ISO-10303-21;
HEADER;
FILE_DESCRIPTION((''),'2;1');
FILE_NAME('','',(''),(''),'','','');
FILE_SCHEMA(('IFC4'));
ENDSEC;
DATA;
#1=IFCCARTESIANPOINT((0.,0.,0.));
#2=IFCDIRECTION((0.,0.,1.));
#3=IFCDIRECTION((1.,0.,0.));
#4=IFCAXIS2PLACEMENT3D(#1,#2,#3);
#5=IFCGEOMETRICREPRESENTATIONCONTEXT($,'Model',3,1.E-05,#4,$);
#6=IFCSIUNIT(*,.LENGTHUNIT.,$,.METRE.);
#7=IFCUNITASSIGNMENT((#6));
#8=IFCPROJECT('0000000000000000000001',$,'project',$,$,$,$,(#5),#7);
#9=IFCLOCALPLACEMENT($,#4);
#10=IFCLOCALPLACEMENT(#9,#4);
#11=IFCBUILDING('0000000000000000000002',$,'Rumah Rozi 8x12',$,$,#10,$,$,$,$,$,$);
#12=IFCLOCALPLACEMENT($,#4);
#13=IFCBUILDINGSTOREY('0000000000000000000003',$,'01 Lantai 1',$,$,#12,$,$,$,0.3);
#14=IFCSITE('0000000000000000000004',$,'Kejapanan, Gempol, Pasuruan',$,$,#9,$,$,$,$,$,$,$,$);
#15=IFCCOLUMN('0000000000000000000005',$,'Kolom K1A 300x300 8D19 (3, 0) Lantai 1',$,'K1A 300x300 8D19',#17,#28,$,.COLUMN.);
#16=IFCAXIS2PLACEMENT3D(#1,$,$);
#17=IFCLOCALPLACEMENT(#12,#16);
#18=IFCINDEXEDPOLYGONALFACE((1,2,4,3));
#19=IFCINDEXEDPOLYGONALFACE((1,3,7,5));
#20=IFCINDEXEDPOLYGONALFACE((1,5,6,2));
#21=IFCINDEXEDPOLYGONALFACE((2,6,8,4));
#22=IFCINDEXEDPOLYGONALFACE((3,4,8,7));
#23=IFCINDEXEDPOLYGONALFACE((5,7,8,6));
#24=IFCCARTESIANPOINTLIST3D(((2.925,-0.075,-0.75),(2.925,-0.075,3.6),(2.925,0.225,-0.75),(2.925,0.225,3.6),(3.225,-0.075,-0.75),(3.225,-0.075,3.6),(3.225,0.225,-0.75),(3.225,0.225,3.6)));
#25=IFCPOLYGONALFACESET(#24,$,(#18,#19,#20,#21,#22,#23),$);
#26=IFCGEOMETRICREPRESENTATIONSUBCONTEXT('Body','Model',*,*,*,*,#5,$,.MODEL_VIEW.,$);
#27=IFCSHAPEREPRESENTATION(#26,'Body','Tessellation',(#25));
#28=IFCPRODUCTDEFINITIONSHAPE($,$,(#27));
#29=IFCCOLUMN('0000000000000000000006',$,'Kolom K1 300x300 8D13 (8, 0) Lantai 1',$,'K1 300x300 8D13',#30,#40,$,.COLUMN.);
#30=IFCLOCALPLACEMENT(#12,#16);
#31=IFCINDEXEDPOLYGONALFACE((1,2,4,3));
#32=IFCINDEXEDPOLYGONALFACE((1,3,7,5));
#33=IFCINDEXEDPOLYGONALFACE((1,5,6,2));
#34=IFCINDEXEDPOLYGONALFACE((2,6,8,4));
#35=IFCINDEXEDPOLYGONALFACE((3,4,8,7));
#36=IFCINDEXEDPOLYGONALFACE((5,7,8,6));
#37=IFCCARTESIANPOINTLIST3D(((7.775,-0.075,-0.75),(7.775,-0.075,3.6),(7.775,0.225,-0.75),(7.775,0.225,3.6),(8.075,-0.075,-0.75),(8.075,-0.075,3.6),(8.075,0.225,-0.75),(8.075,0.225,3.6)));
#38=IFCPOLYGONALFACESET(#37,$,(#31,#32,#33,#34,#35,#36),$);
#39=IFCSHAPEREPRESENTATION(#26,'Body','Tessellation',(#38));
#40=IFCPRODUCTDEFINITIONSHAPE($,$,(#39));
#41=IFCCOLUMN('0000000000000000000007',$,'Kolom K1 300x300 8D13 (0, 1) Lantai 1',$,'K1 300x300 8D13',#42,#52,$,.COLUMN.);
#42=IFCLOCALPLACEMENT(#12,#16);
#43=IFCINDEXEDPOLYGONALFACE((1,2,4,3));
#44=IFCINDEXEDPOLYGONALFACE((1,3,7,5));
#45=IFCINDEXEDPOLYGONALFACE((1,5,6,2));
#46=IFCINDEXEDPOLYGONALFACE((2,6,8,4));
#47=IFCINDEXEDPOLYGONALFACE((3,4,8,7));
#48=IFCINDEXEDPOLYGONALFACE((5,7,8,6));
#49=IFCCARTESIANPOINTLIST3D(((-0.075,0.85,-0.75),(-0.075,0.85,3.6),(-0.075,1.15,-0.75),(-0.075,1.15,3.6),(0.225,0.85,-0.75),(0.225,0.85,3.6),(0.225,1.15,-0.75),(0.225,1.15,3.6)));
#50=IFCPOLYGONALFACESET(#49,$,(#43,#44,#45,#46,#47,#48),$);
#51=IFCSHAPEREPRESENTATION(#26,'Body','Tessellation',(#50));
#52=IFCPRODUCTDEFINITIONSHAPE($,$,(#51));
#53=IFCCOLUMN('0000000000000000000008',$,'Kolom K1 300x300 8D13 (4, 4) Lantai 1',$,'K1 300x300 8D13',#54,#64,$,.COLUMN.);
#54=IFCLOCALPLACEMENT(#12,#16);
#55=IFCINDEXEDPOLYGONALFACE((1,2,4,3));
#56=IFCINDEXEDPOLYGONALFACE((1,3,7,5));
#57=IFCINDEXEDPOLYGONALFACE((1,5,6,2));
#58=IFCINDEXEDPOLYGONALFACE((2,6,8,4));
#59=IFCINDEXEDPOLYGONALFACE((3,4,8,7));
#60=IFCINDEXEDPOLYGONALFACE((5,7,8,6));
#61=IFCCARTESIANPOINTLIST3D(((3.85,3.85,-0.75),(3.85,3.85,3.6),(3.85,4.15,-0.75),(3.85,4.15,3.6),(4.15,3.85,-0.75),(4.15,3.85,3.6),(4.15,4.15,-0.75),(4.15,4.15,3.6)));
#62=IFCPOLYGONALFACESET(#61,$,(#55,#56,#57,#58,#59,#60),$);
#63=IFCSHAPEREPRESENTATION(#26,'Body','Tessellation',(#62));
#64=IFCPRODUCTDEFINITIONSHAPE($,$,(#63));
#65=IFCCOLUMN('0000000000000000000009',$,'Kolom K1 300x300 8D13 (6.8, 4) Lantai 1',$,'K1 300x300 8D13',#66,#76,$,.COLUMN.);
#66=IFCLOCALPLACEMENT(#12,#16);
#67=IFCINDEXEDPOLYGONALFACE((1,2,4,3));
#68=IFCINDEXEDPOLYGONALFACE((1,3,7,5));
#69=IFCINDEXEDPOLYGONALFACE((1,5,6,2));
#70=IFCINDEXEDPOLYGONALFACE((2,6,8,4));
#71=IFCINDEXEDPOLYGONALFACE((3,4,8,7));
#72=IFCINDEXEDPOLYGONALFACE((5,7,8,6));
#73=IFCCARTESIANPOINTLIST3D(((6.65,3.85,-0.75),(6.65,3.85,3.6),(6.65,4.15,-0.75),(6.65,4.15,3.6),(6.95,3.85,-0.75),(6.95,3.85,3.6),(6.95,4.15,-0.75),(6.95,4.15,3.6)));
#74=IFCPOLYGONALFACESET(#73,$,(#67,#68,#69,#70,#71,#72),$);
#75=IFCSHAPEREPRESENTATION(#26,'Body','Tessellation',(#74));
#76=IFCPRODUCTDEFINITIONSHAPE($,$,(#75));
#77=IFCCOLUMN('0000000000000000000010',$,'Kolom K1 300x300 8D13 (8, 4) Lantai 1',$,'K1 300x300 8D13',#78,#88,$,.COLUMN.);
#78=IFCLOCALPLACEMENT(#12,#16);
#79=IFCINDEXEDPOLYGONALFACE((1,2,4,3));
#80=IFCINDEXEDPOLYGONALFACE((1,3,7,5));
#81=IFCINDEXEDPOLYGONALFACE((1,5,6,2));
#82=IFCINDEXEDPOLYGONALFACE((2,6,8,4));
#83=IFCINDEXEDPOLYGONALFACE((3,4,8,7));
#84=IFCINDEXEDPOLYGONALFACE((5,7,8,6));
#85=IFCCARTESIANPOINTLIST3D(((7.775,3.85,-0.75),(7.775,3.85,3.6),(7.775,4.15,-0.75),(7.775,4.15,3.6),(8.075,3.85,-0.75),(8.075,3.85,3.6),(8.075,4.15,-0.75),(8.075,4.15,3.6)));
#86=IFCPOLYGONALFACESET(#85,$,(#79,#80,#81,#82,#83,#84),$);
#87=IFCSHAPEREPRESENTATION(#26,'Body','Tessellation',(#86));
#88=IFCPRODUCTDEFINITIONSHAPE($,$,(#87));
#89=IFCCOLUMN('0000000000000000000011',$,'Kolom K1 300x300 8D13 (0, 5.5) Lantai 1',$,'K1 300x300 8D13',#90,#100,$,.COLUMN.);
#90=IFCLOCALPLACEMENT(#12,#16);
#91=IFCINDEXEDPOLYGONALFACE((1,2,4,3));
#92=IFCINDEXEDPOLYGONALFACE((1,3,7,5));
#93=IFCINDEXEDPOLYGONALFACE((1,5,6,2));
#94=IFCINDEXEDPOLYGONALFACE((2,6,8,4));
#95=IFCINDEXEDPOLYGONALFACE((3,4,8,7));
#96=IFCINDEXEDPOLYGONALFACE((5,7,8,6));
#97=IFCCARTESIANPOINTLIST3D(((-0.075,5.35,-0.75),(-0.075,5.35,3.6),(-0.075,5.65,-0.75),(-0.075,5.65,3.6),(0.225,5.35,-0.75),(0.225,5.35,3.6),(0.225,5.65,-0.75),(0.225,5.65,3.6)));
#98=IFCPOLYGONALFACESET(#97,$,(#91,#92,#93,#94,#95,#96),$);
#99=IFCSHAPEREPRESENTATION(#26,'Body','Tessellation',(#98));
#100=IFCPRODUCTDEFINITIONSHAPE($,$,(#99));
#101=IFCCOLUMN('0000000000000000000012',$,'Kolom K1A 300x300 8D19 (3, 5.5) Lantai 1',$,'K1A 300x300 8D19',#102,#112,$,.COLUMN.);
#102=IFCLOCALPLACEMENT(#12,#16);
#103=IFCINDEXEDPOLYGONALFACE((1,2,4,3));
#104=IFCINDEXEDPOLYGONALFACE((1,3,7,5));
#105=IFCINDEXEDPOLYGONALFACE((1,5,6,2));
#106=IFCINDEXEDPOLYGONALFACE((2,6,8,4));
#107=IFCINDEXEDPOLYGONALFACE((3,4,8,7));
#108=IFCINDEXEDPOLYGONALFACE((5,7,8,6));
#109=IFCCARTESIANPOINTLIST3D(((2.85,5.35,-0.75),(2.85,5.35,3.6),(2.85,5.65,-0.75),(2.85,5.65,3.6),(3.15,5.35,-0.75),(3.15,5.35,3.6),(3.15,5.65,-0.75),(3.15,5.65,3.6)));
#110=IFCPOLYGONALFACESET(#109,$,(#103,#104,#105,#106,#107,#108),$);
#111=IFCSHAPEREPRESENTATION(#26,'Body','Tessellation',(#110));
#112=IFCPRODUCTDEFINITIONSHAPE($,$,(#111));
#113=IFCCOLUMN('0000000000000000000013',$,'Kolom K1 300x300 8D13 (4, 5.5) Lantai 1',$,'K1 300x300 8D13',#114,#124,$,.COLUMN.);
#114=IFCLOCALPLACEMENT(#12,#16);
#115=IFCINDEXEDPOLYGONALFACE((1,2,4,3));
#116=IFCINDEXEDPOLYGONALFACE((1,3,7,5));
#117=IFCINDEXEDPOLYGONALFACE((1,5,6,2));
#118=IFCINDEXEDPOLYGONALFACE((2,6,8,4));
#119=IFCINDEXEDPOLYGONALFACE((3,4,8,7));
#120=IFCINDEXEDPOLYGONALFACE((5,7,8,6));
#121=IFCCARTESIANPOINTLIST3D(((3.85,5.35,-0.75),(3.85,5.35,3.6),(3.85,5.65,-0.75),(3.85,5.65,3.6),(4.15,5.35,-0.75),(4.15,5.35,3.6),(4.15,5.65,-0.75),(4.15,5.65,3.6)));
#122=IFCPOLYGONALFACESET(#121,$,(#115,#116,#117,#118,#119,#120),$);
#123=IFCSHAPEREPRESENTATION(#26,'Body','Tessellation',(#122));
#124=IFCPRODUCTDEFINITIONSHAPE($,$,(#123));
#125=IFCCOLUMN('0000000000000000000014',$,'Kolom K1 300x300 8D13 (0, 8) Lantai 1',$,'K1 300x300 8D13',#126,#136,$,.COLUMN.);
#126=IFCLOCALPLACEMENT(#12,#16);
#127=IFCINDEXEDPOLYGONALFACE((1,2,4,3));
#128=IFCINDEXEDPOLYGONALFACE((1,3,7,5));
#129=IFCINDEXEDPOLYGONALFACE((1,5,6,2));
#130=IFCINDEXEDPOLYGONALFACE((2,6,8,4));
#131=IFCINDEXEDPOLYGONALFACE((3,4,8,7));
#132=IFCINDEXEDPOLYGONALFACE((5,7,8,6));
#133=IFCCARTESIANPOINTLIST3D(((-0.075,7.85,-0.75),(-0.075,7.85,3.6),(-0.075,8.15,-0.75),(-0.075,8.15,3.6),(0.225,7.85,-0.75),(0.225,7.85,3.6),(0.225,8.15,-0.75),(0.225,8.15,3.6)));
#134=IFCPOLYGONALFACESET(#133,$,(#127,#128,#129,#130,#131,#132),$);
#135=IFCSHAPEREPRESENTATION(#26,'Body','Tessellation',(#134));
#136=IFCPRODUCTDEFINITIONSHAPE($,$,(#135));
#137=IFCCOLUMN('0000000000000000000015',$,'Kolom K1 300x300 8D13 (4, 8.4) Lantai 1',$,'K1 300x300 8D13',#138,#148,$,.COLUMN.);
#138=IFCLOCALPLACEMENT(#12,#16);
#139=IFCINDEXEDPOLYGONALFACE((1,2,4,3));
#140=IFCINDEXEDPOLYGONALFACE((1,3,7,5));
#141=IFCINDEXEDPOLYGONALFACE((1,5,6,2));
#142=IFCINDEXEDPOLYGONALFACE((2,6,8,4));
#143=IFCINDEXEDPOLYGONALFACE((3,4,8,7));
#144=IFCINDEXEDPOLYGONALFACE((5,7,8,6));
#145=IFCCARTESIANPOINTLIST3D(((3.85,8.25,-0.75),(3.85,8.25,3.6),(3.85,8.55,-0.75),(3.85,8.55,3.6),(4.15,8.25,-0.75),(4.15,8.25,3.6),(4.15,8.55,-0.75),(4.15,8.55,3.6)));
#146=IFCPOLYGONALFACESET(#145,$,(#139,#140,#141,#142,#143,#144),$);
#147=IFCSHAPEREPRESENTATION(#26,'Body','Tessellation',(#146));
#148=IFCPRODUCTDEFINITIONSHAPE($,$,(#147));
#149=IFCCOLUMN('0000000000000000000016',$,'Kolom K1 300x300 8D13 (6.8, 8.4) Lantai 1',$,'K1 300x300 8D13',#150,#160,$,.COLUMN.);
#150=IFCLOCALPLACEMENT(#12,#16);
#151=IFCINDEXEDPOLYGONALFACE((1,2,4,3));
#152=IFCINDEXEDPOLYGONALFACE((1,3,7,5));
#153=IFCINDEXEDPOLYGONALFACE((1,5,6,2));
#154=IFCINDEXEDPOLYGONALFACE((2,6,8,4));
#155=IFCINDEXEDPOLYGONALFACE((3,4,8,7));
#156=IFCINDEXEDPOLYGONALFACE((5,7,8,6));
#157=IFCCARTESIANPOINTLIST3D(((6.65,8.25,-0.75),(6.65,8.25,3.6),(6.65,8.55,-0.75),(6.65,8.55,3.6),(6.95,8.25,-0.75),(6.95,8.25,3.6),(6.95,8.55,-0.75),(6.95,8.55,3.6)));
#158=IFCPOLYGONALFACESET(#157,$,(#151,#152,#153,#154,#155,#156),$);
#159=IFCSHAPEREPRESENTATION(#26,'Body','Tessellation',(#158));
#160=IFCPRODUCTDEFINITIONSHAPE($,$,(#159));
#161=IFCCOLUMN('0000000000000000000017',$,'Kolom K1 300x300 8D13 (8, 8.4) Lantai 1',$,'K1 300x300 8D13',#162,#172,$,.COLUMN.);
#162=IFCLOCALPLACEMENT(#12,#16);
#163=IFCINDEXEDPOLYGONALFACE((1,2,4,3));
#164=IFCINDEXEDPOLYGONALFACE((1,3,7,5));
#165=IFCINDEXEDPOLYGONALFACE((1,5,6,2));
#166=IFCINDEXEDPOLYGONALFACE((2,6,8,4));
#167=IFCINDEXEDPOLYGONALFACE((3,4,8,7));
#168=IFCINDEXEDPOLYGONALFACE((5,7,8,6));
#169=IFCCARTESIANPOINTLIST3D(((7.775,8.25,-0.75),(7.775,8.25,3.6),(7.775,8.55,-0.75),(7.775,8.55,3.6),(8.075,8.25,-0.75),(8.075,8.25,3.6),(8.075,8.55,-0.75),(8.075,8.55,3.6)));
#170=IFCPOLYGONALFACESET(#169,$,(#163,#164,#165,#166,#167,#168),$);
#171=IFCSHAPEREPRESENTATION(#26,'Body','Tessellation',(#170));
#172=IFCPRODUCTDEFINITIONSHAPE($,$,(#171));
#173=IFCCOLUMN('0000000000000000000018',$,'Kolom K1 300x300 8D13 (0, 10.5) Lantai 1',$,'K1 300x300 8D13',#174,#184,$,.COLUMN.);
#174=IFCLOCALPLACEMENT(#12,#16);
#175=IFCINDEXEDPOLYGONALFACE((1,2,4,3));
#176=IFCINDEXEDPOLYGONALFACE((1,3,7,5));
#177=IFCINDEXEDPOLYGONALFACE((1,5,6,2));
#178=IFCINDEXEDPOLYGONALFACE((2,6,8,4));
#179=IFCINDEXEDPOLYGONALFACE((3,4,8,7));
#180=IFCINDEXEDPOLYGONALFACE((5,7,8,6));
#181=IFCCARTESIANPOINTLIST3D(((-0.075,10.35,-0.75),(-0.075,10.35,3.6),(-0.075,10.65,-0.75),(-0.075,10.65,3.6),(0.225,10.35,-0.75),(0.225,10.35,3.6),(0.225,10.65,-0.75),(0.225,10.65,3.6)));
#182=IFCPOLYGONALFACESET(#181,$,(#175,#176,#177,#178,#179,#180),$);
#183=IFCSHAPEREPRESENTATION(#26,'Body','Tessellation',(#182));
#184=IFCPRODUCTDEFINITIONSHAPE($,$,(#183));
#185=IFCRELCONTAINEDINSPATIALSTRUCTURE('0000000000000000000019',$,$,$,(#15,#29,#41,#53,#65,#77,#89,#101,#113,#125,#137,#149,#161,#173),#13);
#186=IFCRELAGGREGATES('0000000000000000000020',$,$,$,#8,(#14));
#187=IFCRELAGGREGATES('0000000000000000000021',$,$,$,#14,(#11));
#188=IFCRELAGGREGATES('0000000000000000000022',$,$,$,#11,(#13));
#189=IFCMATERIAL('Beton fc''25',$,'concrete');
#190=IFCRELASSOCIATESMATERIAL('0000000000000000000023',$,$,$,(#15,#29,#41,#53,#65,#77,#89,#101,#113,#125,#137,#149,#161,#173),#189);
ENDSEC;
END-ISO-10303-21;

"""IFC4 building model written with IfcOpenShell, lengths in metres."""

from ifc_helpers import new_model, si_unit, frame, origin_with_axes, place, context, subcontext, project, spatial, line, indexed_curve, outline, extrude, material, element, save


model = new_model("IFC4")

# Units and contexts
model_context = context("Model", 3, precision=1e-05, world=origin_with_axes())
body_context = subcontext(model_context, "Body", "Model", "MODEL_VIEW")
ifc_project = project(units=[si_unit("LENGTHUNIT", "METRE")], contexts=[model_context])

# Site, building, storey
site_placement = place(None, origin_with_axes())
site = spatial("IfcSite", under=ifc_project, at=site_placement, Name="Kejapanan, Gempol, Pasuruan")
building_placement = place(site_placement, origin_with_axes())
building = spatial("IfcBuilding", under=site, at=building_placement, Name="Rumah Rozi 8x12")
storey_placement = place(None, origin_with_axes())
storey = spatial("IfcBuildingStorey", under=building, at=storey_placement, Name="01 Lantai 1", Elevation=0.3)

# Columns
ifc_material = material(Name="Beton fc'25", Category="concrete")
column_1_placement = place(storey_placement, origin_with_axes())
element("IfcColumn", 1, at=column_1_placement, inside=storey, material=ifc_material, Name="Kolom K1A 300x300 8D19 (3, 0) Lantai 1", ObjectType="K1A 300x300 8D19", PredefinedType="COLUMN", context=body_context, shape_type="SweptSolid", body=[
    extrude(outline(indexed_curve([(2.925, -0.075), (3.225, -0.075), (3.225, 0.225), (2.925, 0.225)], segments=[line(1, 2, 3, 4, 1)])), frame((0.0, 0.0, -0.75), z_axis=(0.0, 0.0, 1.0), x_axis=(1.0, 0.0, 0.0)), (0.0, 0.0, 1.0), 4.35),
])
column_2_placement = place(storey_placement, origin_with_axes())
element("IfcColumn", 2, at=column_2_placement, inside=storey, material=ifc_material, Name="Kolom K1 300x300 8D13 (8, 0) Lantai 1", ObjectType="K1 300x300 8D13", PredefinedType="COLUMN", context=body_context, shape_type="SweptSolid", body=[
    extrude(outline(indexed_curve([(7.775, -0.075), (8.075, -0.075), (8.075, 0.225), (7.775, 0.225)], segments=[line(1, 2, 3, 4, 1)])), frame((0.0, 0.0, -0.75), z_axis=(0.0, 0.0, 1.0), x_axis=(1.0, 0.0, 0.0)), (0.0, 0.0, 1.0), 4.35),
])
column_3_placement = place(storey_placement, origin_with_axes())
element("IfcColumn", 3, at=column_3_placement, inside=storey, material=ifc_material, Name="Kolom K1 300x300 8D13 (0, 1) Lantai 1", ObjectType="K1 300x300 8D13", PredefinedType="COLUMN", context=body_context, shape_type="SweptSolid", body=[
    extrude(outline(indexed_curve([(-0.075, 0.85), (0.225, 0.85), (0.225, 1.15), (-0.075, 1.15)], segments=[line(1, 2, 3, 4, 1)])), frame((0.0, 0.0, -0.75), z_axis=(0.0, 0.0, 1.0), x_axis=(1.0, 0.0, 0.0)), (0.0, 0.0, 1.0), 4.35),
])
column_4_placement = place(storey_placement, origin_with_axes())
element("IfcColumn", 4, at=column_4_placement, inside=storey, material=ifc_material, Name="Kolom K1 300x300 8D13 (4, 4) Lantai 1", ObjectType="K1 300x300 8D13", PredefinedType="COLUMN", context=body_context, shape_type="SweptSolid", body=[
    extrude(outline(indexed_curve([(3.85, 3.85), (4.15, 3.85), (4.15, 4.15), (3.85, 4.15)], segments=[line(1, 2, 3, 4, 1)])), frame((0.0, 0.0, -0.75), z_axis=(0.0, 0.0, 1.0), x_axis=(1.0, 0.0, 0.0)), (0.0, 0.0, 1.0), 4.35),
])
column_5_placement = place(storey_placement, origin_with_axes())
element("IfcColumn", 5, at=column_5_placement, inside=storey, material=ifc_material, Name="Kolom K1 300x300 8D13 (6.8, 4) Lantai 1", ObjectType="K1 300x300 8D13", PredefinedType="COLUMN", context=body_context, shape_type="SweptSolid", body=[
    extrude(outline(indexed_curve([(6.65, 3.85), (6.95, 3.85), (6.95, 4.15), (6.65, 4.15)], segments=[line(1, 2, 3, 4, 1)])), frame((0.0, 0.0, -0.75), z_axis=(0.0, 0.0, 1.0), x_axis=(1.0, 0.0, 0.0)), (0.0, 0.0, 1.0), 4.35),
])
column_6_placement = place(storey_placement, origin_with_axes())
element("IfcColumn", 6, at=column_6_placement, inside=storey, material=ifc_material, Name="Kolom K1 300x300 8D13 (8, 4) Lantai 1", ObjectType="K1 300x300 8D13", PredefinedType="COLUMN", context=body_context, shape_type="SweptSolid", body=[
    extrude(outline(indexed_curve([(7.775, 3.85), (8.075, 3.85), (8.075, 4.15), (7.775, 4.15)], segments=[line(1, 2, 3, 4, 1)])), frame((0.0, 0.0, -0.75), z_axis=(0.0, 0.0, 1.0), x_axis=(1.0, 0.0, 0.0)), (0.0, 0.0, 1.0), 4.35),
])
column_7_placement = place(storey_placement, origin_with_axes())
element("IfcColumn", 7, at=column_7_placement, inside=storey, material=ifc_material, Name="Kolom K1 300x300 8D13 (0, 5.5) Lantai 1", ObjectType="K1 300x300 8D13", PredefinedType="COLUMN", context=body_context, shape_type="SweptSolid", body=[
    extrude(outline(indexed_curve([(-0.075, 5.35), (0.225, 5.35), (0.225, 5.65), (-0.075, 5.65)], segments=[line(1, 2, 3, 4, 1)])), frame((0.0, 0.0, -0.75), z_axis=(0.0, 0.0, 1.0), x_axis=(1.0, 0.0, 0.0)), (0.0, 0.0, 1.0), 4.35),
])
column_8_placement = place(storey_placement, origin_with_axes())
element("IfcColumn", 8, at=column_8_placement, inside=storey, material=ifc_material, Name="Kolom K1A 300x300 8D19 (3, 5.5) Lantai 1", ObjectType="K1A 300x300 8D19", PredefinedType="COLUMN", context=body_context, shape_type="SweptSolid", body=[
    extrude(outline(indexed_curve([(2.85, 5.35), (3.15, 5.35), (3.15, 5.65), (2.85, 5.65)], segments=[line(1, 2, 3, 4, 1)])), frame((0.0, 0.0, -0.75), z_axis=(0.0, 0.0, 1.0), x_axis=(1.0, 0.0, 0.0)), (0.0, 0.0, 1.0), 4.35),
])
column_9_placement = place(storey_placement, origin_with_axes())
element("IfcColumn", 9, at=column_9_placement, inside=storey, material=ifc_material, Name="Kolom K1 300x300 8D13 (4, 5.5) Lantai 1", ObjectType="K1 300x300 8D13", PredefinedType="COLUMN", context=body_context, shape_type="SweptSolid", body=[
    extrude(outline(indexed_curve([(3.85, 5.35), (4.15, 5.35), (4.15, 5.65), (3.85, 5.65)], segments=[line(1, 2, 3, 4, 1)])), frame((0.0, 0.0, -0.75), z_axis=(0.0, 0.0, 1.0), x_axis=(1.0, 0.0, 0.0)), (0.0, 0.0, 1.0), 4.35),
])
column_10_placement = place(storey_placement, origin_with_axes())
element("IfcColumn", 10, at=column_10_placement, inside=storey, material=ifc_material, Name="Kolom K1 300x300 8D13 (0, 8) Lantai 1", ObjectType="K1 300x300 8D13", PredefinedType="COLUMN", context=body_context, shape_type="SweptSolid", body=[
    extrude(outline(indexed_curve([(-0.075, 7.85), (0.225, 7.85), (0.225, 8.15), (-0.075, 8.15)], segments=[line(1, 2, 3, 4, 1)])), frame((0.0, 0.0, -0.75), z_axis=(0.0, 0.0, 1.0), x_axis=(1.0, 0.0, 0.0)), (0.0, 0.0, 1.0), 4.35),
])
column_11_placement = place(storey_placement, origin_with_axes())
element("IfcColumn", 11, at=column_11_placement, inside=storey, material=ifc_material, Name="Kolom K1 300x300 8D13 (4, 8.4) Lantai 1", ObjectType="K1 300x300 8D13", PredefinedType="COLUMN", context=body_context, shape_type="SweptSolid", body=[
    extrude(outline(indexed_curve([(3.85, 8.25), (4.15, 8.25), (4.15, 8.55), (3.85, 8.55)], segments=[line(1, 2, 3, 4, 1)])), frame((0.0, 0.0, -0.75), z_axis=(0.0, 0.0, 1.0), x_axis=(1.0, 0.0, 0.0)), (0.0, 0.0, 1.0), 4.35),
])
column_12_placement = place(storey_placement, origin_with_axes())
element("IfcColumn", 12, at=column_12_placement, inside=storey, material=ifc_material, Name="Kolom K1 300x300 8D13 (6.8, 8.4) Lantai 1", ObjectType="K1 300x300 8D13", PredefinedType="COLUMN", context=body_context, shape_type="SweptSolid", body=[
    extrude(outline(indexed_curve([(6.65, 8.25), (6.95, 8.25), (6.95, 8.55), (6.65, 8.55)], segments=[line(1, 2, 3, 4, 1)])), frame((0.0, 0.0, -0.75), z_axis=(0.0, 0.0, 1.0), x_axis=(1.0, 0.0, 0.0)), (0.0, 0.0, 1.0), 4.35),
])
column_13_placement = place(storey_placement, origin_with_axes())
element("IfcColumn", 13, at=column_13_placement, inside=storey, material=ifc_material, Name="Kolom K1 300x300 8D13 (8, 8.4) Lantai 1", ObjectType="K1 300x300 8D13", PredefinedType="COLUMN", context=body_context, shape_type="SweptSolid", body=[
    extrude(outline(indexed_curve([(7.775, 8.25), (8.075, 8.25), (8.075, 8.55), (7.775, 8.55)], segments=[line(1, 2, 3, 4, 1)])), frame((0.0, 0.0, -0.75), z_axis=(0.0, 0.0, 1.0), x_axis=(1.0, 0.0, 0.0)), (0.0, 0.0, 1.0), 4.35),
])
column_14_placement = place(storey_placement, origin_with_axes())
element("IfcColumn", 14, at=column_14_placement, inside=storey, material=ifc_material, Name="Kolom K1 300x300 8D13 (0, 10.5) Lantai 1", ObjectType="K1 300x300 8D13", PredefinedType="COLUMN", context=body_context, shape_type="SweptSolid", body=[
    extrude(outline(indexed_curve([(-0.075, 10.35), (0.225, 10.35), (0.225, 10.65), (-0.075, 10.65)], segments=[line(1, 2, 3, 4, 1)])), frame((0.0, 0.0, -0.75), z_axis=(0.0, 0.0, 1.0), x_axis=(1.0, 0.0, 0.0)), (0.0, 0.0, 1.0), 4.35),
])

save(model, "model.ifc")
